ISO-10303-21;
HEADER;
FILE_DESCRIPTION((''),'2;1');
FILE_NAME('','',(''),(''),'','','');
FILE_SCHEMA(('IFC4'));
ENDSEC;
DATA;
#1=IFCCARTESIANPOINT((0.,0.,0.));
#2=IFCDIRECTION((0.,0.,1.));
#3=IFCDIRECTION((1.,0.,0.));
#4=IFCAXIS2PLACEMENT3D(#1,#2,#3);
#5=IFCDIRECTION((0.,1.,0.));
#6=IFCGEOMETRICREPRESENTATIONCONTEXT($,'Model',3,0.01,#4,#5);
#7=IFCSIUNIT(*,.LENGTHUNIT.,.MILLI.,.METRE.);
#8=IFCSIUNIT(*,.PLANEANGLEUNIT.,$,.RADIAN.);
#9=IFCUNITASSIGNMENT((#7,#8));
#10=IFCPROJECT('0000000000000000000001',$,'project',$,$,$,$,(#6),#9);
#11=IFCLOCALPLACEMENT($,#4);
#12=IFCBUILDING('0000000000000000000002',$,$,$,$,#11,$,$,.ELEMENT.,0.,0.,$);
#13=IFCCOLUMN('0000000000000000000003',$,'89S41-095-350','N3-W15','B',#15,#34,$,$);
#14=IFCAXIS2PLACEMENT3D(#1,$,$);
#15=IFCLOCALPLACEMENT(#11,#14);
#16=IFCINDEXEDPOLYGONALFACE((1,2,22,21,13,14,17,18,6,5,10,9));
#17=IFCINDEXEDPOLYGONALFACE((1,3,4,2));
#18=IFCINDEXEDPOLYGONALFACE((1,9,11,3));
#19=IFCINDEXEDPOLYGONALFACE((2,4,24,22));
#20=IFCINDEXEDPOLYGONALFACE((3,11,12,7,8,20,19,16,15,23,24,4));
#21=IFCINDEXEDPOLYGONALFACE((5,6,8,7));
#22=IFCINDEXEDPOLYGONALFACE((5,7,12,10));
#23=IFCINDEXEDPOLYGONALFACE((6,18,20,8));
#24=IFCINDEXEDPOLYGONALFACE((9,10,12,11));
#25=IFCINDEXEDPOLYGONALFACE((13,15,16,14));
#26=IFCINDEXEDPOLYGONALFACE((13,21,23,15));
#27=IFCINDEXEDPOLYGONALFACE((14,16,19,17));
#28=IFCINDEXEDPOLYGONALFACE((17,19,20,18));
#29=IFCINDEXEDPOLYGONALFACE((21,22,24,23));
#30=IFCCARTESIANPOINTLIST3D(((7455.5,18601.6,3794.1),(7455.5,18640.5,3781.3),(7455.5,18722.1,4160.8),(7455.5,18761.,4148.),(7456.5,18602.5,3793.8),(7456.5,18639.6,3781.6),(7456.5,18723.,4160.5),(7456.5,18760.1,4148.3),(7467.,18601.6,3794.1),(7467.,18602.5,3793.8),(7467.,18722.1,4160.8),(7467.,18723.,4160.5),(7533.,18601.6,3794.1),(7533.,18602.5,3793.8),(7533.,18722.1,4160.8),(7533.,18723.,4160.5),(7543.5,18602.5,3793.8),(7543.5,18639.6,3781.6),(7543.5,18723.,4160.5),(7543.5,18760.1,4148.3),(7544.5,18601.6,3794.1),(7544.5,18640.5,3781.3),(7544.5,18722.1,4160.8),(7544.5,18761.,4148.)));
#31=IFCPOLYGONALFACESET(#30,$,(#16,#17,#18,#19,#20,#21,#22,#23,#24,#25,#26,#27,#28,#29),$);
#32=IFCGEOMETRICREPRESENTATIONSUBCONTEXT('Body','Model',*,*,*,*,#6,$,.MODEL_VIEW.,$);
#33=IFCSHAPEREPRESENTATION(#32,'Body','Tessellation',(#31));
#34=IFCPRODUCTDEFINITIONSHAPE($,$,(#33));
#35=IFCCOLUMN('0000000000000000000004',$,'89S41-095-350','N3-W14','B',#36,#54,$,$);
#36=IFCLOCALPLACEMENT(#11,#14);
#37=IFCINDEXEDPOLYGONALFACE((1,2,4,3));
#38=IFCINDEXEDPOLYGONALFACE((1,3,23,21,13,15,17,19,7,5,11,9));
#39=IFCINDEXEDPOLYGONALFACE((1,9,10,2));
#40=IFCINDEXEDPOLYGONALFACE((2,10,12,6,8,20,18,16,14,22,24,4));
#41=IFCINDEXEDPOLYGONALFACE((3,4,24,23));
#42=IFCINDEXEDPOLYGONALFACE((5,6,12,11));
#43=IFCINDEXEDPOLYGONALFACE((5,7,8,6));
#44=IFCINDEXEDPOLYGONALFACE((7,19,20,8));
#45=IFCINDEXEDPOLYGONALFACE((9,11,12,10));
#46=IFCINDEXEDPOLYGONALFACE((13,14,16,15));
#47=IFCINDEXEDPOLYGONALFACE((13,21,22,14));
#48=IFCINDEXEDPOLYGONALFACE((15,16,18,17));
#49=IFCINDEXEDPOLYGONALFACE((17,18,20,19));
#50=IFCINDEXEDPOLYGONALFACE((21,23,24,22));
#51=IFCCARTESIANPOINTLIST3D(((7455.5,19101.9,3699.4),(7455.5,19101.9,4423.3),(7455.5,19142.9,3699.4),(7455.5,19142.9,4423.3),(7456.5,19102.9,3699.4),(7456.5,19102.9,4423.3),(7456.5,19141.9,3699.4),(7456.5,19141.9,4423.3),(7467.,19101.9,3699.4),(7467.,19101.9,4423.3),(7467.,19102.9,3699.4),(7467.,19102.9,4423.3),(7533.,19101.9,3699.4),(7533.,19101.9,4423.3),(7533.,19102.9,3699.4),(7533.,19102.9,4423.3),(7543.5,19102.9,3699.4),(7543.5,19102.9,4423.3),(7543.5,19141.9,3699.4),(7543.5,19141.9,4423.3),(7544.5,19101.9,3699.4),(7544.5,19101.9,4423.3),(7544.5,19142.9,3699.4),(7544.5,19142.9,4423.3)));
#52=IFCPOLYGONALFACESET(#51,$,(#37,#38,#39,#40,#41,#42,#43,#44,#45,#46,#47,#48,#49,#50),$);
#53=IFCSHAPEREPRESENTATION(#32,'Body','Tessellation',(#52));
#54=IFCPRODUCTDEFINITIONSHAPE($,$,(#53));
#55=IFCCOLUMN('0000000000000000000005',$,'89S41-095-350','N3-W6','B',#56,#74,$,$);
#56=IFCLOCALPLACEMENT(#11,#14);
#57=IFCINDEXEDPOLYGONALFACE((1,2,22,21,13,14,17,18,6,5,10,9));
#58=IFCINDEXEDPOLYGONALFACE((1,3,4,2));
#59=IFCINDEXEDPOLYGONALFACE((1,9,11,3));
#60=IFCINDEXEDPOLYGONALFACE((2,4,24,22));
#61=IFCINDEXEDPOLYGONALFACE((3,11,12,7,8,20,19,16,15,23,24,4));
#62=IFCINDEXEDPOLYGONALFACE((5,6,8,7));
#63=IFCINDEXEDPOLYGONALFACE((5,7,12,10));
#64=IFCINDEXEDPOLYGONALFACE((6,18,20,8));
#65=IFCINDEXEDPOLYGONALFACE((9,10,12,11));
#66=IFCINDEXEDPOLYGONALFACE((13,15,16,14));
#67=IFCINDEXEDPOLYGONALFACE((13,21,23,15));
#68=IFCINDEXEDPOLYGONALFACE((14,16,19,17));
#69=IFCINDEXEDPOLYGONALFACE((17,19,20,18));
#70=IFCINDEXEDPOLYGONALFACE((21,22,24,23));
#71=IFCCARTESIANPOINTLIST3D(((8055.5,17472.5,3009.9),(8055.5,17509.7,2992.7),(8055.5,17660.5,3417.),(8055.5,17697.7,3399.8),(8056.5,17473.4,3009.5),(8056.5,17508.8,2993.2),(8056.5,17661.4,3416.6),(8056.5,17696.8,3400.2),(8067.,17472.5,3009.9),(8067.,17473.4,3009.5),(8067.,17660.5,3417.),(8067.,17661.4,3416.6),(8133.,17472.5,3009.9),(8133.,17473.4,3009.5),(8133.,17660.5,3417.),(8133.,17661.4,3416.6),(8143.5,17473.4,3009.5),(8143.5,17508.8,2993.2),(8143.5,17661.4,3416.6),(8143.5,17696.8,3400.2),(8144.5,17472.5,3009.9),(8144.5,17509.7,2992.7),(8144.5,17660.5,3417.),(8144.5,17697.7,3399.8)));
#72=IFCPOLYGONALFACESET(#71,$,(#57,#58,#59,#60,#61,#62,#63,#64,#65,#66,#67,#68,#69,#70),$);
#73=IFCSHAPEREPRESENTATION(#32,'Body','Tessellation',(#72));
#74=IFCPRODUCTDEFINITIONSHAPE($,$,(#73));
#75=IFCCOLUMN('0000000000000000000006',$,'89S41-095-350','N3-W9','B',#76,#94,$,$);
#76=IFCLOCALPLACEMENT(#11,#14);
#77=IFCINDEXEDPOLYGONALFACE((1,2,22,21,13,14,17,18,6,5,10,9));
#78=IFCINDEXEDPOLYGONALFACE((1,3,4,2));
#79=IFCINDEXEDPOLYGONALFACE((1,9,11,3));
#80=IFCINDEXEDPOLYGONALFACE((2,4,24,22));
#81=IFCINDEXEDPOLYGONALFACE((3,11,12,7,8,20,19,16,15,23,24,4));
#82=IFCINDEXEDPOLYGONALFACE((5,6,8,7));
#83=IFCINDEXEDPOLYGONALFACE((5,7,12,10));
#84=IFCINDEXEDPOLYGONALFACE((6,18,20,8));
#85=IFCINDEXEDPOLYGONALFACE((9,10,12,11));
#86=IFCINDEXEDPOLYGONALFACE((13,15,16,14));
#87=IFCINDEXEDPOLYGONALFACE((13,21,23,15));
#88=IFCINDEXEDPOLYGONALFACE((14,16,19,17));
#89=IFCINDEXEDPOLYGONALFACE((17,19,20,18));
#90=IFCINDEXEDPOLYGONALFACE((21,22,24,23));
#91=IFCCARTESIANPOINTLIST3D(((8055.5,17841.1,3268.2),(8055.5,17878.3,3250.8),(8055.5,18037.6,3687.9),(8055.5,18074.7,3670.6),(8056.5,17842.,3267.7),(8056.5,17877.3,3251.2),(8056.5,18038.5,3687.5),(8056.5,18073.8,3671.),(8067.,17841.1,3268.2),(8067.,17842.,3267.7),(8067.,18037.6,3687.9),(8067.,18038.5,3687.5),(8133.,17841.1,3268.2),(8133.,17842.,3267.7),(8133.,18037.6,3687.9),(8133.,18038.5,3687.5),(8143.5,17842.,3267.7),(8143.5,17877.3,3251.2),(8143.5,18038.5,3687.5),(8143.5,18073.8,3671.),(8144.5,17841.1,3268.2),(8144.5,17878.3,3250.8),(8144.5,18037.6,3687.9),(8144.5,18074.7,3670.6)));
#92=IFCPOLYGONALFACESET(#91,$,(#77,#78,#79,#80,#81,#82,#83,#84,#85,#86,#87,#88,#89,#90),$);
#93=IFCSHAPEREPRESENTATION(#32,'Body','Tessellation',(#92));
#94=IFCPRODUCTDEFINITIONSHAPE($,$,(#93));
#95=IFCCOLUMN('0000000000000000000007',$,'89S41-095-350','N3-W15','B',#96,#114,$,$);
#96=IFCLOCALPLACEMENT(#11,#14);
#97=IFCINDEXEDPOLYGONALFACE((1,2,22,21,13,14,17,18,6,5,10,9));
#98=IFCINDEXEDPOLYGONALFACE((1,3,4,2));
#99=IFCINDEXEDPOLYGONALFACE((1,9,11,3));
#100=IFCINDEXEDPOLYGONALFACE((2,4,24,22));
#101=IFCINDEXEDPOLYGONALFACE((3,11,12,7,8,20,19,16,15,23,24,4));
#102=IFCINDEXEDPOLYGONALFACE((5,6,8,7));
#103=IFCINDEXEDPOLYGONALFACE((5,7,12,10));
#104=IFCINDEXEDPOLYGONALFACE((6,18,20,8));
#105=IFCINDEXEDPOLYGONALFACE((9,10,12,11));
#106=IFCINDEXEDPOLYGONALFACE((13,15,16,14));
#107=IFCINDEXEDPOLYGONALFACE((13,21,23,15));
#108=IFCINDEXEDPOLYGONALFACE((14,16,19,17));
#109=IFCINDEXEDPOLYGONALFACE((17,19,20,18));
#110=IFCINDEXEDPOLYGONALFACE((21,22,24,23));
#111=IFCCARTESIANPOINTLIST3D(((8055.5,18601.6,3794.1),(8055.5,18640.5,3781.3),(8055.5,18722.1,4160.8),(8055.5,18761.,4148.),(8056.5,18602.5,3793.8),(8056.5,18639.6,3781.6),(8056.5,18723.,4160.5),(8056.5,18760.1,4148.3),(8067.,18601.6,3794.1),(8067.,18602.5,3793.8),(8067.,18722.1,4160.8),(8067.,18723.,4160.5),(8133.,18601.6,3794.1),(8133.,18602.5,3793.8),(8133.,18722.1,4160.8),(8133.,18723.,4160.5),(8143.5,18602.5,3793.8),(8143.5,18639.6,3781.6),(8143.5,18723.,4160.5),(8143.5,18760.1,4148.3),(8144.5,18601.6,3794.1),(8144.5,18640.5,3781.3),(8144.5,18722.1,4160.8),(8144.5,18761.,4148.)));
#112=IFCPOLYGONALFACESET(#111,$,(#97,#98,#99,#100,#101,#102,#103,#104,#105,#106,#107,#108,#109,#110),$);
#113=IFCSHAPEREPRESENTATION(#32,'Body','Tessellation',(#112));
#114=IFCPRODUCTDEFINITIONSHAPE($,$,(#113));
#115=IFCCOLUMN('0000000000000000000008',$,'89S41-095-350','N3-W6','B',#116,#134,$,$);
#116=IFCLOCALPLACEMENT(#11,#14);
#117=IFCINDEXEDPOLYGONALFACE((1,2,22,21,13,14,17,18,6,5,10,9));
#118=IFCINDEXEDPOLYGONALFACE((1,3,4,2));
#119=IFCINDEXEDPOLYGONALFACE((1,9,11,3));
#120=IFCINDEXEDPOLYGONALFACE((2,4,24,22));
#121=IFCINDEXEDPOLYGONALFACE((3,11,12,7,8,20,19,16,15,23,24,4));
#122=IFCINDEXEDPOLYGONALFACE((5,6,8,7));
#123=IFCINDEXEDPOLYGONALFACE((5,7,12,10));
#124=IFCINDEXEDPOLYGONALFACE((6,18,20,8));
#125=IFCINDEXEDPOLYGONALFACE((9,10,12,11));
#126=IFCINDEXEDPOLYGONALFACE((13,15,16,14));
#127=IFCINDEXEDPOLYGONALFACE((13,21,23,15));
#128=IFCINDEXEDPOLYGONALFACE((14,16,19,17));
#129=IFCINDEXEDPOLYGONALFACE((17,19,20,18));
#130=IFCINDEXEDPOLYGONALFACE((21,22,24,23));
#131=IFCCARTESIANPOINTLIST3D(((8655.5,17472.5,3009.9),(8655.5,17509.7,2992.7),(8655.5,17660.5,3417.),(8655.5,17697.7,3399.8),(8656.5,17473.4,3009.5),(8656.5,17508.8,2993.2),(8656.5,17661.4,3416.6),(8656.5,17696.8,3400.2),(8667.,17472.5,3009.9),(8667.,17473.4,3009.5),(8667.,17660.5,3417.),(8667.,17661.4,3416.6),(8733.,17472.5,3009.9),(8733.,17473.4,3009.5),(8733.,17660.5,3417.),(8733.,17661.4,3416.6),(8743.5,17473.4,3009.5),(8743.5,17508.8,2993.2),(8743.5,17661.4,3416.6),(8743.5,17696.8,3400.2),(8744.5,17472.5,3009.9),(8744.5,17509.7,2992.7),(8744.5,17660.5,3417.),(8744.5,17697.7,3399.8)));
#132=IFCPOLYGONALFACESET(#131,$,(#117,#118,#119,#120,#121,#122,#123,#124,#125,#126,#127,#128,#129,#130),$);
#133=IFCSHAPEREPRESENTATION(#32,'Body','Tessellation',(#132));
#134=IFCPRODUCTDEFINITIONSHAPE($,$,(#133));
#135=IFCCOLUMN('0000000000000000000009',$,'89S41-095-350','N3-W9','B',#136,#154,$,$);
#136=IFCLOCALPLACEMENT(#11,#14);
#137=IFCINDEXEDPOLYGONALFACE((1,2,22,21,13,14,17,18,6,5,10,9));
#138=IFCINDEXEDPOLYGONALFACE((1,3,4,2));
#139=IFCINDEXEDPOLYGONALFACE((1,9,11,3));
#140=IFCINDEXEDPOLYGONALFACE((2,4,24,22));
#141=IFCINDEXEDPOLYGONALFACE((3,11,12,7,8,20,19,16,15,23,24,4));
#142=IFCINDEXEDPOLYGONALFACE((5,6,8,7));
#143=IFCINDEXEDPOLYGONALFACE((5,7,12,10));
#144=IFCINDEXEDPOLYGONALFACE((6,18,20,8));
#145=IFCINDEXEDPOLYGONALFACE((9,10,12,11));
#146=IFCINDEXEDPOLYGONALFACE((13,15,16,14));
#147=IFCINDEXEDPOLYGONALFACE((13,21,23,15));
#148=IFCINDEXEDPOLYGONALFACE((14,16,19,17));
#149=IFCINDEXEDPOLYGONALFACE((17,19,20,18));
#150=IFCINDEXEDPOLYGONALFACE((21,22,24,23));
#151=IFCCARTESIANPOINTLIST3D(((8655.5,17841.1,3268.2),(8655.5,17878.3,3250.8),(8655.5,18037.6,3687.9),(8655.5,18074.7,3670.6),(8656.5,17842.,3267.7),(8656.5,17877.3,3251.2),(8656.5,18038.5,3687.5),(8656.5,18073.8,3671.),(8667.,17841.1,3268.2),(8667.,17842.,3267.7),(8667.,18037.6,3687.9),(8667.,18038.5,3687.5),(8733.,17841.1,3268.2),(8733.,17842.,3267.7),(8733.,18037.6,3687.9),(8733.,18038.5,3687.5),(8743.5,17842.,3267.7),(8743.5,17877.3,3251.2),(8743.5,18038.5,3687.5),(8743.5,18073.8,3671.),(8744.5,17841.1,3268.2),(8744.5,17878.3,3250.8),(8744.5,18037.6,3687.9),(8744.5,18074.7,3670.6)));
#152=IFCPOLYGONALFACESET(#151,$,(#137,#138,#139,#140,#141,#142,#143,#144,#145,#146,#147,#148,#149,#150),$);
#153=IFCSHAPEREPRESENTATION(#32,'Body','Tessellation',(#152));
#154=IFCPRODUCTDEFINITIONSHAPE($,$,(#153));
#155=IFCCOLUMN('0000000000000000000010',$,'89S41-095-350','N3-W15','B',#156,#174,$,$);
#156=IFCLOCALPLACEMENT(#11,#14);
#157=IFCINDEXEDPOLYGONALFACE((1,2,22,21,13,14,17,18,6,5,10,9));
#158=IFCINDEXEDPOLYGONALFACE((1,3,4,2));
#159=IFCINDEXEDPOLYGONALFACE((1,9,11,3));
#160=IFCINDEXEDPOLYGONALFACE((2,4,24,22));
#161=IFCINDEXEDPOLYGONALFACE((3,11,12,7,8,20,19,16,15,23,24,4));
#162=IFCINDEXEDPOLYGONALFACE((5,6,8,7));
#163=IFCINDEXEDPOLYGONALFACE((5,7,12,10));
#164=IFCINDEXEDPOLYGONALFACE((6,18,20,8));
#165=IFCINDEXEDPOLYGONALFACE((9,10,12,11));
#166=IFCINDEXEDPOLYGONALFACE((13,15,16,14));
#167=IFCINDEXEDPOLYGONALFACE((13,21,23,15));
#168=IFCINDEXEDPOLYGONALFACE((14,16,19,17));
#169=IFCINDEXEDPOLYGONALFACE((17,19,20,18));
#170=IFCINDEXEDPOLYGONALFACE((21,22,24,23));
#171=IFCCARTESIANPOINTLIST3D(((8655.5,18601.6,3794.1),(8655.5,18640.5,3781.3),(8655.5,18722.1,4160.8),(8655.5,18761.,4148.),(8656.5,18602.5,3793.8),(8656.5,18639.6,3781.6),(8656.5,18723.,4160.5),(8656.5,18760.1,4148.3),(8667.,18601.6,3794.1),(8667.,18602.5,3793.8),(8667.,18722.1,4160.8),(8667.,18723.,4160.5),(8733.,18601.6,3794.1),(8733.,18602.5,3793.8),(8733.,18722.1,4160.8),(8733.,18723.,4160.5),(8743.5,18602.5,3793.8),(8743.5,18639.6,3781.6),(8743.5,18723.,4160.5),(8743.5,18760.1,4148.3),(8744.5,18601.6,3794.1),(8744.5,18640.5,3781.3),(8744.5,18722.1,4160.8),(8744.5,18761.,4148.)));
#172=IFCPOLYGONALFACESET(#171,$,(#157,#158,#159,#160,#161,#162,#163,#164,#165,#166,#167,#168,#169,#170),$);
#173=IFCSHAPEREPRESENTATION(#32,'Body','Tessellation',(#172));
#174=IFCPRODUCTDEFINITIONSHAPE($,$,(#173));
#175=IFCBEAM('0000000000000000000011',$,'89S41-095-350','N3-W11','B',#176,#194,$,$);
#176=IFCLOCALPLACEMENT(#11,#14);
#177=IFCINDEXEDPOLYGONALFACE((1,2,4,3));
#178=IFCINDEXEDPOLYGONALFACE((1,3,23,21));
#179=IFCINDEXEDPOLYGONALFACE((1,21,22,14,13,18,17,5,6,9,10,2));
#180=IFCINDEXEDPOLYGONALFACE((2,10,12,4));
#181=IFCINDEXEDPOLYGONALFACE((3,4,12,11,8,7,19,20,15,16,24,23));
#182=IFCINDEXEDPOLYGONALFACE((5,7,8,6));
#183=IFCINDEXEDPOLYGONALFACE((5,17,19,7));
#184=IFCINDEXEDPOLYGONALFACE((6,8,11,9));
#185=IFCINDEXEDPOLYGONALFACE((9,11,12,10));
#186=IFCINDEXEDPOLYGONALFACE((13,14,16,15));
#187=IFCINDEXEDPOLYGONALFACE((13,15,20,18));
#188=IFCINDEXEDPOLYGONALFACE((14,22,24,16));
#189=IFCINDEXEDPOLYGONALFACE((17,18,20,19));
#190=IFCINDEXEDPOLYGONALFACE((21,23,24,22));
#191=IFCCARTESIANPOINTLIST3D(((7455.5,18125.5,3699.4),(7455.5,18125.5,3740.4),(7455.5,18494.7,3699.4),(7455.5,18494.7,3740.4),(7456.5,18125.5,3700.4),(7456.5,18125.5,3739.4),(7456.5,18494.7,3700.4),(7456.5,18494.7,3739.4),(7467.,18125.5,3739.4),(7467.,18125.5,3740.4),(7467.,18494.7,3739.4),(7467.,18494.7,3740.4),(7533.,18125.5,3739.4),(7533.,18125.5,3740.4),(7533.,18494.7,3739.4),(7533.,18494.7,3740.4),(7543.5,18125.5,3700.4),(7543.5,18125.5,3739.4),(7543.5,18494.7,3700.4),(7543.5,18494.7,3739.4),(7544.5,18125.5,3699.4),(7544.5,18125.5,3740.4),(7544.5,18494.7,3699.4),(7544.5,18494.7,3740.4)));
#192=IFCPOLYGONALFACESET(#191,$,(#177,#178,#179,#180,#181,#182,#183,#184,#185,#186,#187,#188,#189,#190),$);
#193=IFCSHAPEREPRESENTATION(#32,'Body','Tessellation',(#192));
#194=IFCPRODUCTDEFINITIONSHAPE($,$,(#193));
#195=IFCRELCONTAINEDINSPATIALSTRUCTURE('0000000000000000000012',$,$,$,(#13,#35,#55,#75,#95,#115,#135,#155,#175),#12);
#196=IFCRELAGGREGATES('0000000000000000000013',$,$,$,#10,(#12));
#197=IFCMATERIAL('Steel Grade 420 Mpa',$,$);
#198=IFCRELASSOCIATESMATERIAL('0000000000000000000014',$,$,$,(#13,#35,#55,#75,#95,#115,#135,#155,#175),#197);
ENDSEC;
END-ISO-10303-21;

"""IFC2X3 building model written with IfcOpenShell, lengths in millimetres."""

from ifc_helpers import new_model, si_unit, direction, frame, origin, origin_with_axes, origin_2d_with_axis, place, context, subcontext, project, spatial, c_section, extrude, source, transform, mapped, material, element, save


model = new_model("IFC2X3")

# Units and contexts
model_context = context("Model", 3, precision=0.01, world=origin_with_axes(), true_north=direction((0.0, 1.0, 0.0)))
body_context = subcontext(model_context, "Body", "Model", "MODEL_VIEW")
ifc_project = project(units=[si_unit("LENGTHUNIT", "METRE", prefix="MILLI"), si_unit("PLANEANGLEUNIT", "RADIAN")], contexts=[model_context])

# Building
building_placement = place(None, origin_with_axes())
building = spatial("IfcBuilding", under=ifc_project, at=building_placement, CompositionType="ELEMENT", ElevationOfRefHeight=0.0, ElevationOfTerrain=0.0)

# Columns
ifc_material = material(Name="Steel Grade 420 Mpa")
shared_shape_1 = source(origin(), body_context, "Body", "SweptSolid", [
    extrude(c_section(Depth=89.0, Width=41.0, WallThickness=1.0, Girth=11.5, at=origin_2d_with_axis()), origin_with_axes(), (0.0, 0.0, 1.0), 385.9),
])
column_1_placement = place(None, frame((7500.0, 18741.5, 4154.4), z_axis=(0.0, -0.312196, -0.950018), x_axis=(0.0, -0.950018, 0.312196)))
element("IfcColumn", 1, at=column_1_placement, inside=building, material=ifc_material, Name="89S41-095-350", Description="N3-W15", ObjectType="B", context=body_context, shape_type="MappedRepresentation", body=[
    mapped(shared_shape_1, transform((0.0, 0.0, 0.0), scale=1.0)),
])
shared_shape_2 = source(origin(), body_context, "Body", "SweptSolid", [
    extrude(c_section(Depth=89.0, Width=41.0, WallThickness=1.0, Girth=11.5, at=origin_2d_with_axis()), origin_with_axes(), (0.0, 0.0, 1.0), 723.9),
])
column_2_placement = place(None, frame((7500.0, 19122.4, 4423.3), z_axis=(0.0, 0.0, -1.0), x_axis=(0.0, -1.0, 0.0)))
element("IfcColumn", 2, at=column_2_placement, inside=building, material=ifc_material, Name="89S41-095-350", Description="N3-W14", ObjectType="B", context=body_context, shape_type="MappedRepresentation", body=[
    mapped(shared_shape_2, transform((0.0, 0.0, 0.0), scale=1.0)),
])
shared_shape_3 = source(origin(), body_context, "Body", "SweptSolid", [
    extrude(c_section(Depth=89.0, Width=41.0, WallThickness=1.0, Girth=11.5, at=origin_2d_with_axis()), origin_with_axes(), (0.0, 0.0, 1.0), 448.4),
])
column_3_placement = place(None, frame((8100.0, 17679.1, 3408.4), z_axis=(0.0, -0.419234, -0.907878), x_axis=(0.0, -0.907878, 0.419234)))
element("IfcColumn", 3, at=column_3_placement, inside=building, material=ifc_material, Name="89S41-095-350", Description="N3-W6", ObjectType="B", context=body_context, shape_type="MappedRepresentation", body=[
    mapped(shared_shape_3, transform((0.0, 0.0, 0.0), scale=1.0)),
])
shared_shape_4 = source(origin(), body_context, "Body", "SweptSolid", [
    extrude(c_section(Depth=89.0, Width=41.0, WallThickness=1.0, Girth=11.5, at=origin_2d_with_axis()), origin_with_axes(), (0.0, 0.0, 1.0), 463.5),
])
column_4_placement = place(None, frame((8100.0, 18056.1, 3679.2), z_axis=(0.0, -0.423875, -0.905721), x_axis=(0.0, -0.905721, 0.423875)))
element("IfcColumn", 4, at=column_4_placement, inside=building, material=ifc_material, Name="89S41-095-350", Description="N3-W9", ObjectType="B", context=body_context, shape_type="MappedRepresentation", body=[
    mapped(shared_shape_4, transform((0.0, 0.0, 0.0), scale=1.0)),
])
shared_shape_5 = source(origin(), body_context, "Body", "SweptSolid", [
    extrude(c_section(Depth=89.0, Width=41.0, WallThickness=1.0, Girth=11.5, at=origin_2d_with_axis()), origin_with_axes(), (0.0, 0.0, 1.0), 385.9),
])
column_5_placement = place(None, frame((8100.0, 18741.5, 4154.4), z_axis=(0.0, -0.312196, -0.950018), x_axis=(0.0, -0.950018, 0.312196)))
element("IfcColumn", 5, at=column_5_placement, inside=building, material=ifc_material, Name="89S41-095-350", Description="N3-W15", ObjectType="B", context=body_context, shape_type="MappedRepresentation", body=[
    mapped(shared_shape_5, transform((0.0, 0.0, 0.0), scale=1.0)),
])
shared_shape_6 = source(origin(), body_context, "Body", "SweptSolid", [
    extrude(c_section(Depth=89.0, Width=41.0, WallThickness=1.0, Girth=11.5, at=origin_2d_with_axis()), origin_with_axes(), (0.0, 0.0, 1.0), 448.4),
])
column_6_placement = place(None, frame((8700.0, 17679.1, 3408.4), z_axis=(0.0, -0.419234, -0.907878), x_axis=(0.0, -0.907878, 0.419234)))
element("IfcColumn", 6, at=column_6_placement, inside=building, material=ifc_material, Name="89S41-095-350", Description="N3-W6", ObjectType="B", context=body_context, shape_type="MappedRepresentation", body=[
    mapped(shared_shape_6, transform((0.0, 0.0, 0.0), scale=1.0)),
])
shared_shape_7 = source(origin(), body_context, "Body", "SweptSolid", [
    extrude(c_section(Depth=89.0, Width=41.0, WallThickness=1.0, Girth=11.5, at=origin_2d_with_axis()), origin_with_axes(), (0.0, 0.0, 1.0), 463.5),
])
column_7_placement = place(None, frame((8700.0, 18056.1, 3679.2), z_axis=(0.0, -0.423875, -0.905721), x_axis=(0.0, -0.905721, 0.423875)))
element("IfcColumn", 7, at=column_7_placement, inside=building, material=ifc_material, Name="89S41-095-350", Description="N3-W9", ObjectType="B", context=body_context, shape_type="MappedRepresentation", body=[
    mapped(shared_shape_7, transform((0.0, 0.0, 0.0), scale=1.0)),
])
shared_shape_8 = source(origin(), body_context, "Body", "SweptSolid", [
    extrude(c_section(Depth=89.0, Width=41.0, WallThickness=1.0, Girth=11.5, at=origin_2d_with_axis()), origin_with_axes(), (0.0, 0.0, 1.0), 385.9),
])
column_8_placement = place(None, frame((8700.0, 18741.5, 4154.4), z_axis=(0.0, -0.312196, -0.950018), x_axis=(0.0, -0.950018, 0.312196)))
element("IfcColumn", 8, at=column_8_placement, inside=building, material=ifc_material, Name="89S41-095-350", Description="N3-W15", ObjectType="B", context=body_context, shape_type="MappedRepresentation", body=[
    mapped(shared_shape_8, transform((0.0, 0.0, 0.0), scale=1.0)),
])

# Beam
shared_shape_9 = source(origin(), body_context, "Body", "SweptSolid", [
    extrude(c_section(Depth=89.0, Width=41.0, WallThickness=1.0, Girth=11.5, at=origin_2d_with_axis()), origin_with_axes(), (0.0, 0.0, 1.0), 369.2),
])
beam_1_placement = place(None, frame((7500.0, 18494.7, 3719.9), z_axis=(0.0, -1.0, 0.0), x_axis=(0.0, 0.0, 1.0)))
element("IfcBeam", 9, at=beam_1_placement, inside=building, material=ifc_material, Name="89S41-095-350", Description="N3-W11", ObjectType="B", context=body_context, shape_type="MappedRepresentation", body=[
    mapped(shared_shape_9, transform((0.0, 0.0, 0.0), scale=1.0)),
])

save(model, "model.ifc")
